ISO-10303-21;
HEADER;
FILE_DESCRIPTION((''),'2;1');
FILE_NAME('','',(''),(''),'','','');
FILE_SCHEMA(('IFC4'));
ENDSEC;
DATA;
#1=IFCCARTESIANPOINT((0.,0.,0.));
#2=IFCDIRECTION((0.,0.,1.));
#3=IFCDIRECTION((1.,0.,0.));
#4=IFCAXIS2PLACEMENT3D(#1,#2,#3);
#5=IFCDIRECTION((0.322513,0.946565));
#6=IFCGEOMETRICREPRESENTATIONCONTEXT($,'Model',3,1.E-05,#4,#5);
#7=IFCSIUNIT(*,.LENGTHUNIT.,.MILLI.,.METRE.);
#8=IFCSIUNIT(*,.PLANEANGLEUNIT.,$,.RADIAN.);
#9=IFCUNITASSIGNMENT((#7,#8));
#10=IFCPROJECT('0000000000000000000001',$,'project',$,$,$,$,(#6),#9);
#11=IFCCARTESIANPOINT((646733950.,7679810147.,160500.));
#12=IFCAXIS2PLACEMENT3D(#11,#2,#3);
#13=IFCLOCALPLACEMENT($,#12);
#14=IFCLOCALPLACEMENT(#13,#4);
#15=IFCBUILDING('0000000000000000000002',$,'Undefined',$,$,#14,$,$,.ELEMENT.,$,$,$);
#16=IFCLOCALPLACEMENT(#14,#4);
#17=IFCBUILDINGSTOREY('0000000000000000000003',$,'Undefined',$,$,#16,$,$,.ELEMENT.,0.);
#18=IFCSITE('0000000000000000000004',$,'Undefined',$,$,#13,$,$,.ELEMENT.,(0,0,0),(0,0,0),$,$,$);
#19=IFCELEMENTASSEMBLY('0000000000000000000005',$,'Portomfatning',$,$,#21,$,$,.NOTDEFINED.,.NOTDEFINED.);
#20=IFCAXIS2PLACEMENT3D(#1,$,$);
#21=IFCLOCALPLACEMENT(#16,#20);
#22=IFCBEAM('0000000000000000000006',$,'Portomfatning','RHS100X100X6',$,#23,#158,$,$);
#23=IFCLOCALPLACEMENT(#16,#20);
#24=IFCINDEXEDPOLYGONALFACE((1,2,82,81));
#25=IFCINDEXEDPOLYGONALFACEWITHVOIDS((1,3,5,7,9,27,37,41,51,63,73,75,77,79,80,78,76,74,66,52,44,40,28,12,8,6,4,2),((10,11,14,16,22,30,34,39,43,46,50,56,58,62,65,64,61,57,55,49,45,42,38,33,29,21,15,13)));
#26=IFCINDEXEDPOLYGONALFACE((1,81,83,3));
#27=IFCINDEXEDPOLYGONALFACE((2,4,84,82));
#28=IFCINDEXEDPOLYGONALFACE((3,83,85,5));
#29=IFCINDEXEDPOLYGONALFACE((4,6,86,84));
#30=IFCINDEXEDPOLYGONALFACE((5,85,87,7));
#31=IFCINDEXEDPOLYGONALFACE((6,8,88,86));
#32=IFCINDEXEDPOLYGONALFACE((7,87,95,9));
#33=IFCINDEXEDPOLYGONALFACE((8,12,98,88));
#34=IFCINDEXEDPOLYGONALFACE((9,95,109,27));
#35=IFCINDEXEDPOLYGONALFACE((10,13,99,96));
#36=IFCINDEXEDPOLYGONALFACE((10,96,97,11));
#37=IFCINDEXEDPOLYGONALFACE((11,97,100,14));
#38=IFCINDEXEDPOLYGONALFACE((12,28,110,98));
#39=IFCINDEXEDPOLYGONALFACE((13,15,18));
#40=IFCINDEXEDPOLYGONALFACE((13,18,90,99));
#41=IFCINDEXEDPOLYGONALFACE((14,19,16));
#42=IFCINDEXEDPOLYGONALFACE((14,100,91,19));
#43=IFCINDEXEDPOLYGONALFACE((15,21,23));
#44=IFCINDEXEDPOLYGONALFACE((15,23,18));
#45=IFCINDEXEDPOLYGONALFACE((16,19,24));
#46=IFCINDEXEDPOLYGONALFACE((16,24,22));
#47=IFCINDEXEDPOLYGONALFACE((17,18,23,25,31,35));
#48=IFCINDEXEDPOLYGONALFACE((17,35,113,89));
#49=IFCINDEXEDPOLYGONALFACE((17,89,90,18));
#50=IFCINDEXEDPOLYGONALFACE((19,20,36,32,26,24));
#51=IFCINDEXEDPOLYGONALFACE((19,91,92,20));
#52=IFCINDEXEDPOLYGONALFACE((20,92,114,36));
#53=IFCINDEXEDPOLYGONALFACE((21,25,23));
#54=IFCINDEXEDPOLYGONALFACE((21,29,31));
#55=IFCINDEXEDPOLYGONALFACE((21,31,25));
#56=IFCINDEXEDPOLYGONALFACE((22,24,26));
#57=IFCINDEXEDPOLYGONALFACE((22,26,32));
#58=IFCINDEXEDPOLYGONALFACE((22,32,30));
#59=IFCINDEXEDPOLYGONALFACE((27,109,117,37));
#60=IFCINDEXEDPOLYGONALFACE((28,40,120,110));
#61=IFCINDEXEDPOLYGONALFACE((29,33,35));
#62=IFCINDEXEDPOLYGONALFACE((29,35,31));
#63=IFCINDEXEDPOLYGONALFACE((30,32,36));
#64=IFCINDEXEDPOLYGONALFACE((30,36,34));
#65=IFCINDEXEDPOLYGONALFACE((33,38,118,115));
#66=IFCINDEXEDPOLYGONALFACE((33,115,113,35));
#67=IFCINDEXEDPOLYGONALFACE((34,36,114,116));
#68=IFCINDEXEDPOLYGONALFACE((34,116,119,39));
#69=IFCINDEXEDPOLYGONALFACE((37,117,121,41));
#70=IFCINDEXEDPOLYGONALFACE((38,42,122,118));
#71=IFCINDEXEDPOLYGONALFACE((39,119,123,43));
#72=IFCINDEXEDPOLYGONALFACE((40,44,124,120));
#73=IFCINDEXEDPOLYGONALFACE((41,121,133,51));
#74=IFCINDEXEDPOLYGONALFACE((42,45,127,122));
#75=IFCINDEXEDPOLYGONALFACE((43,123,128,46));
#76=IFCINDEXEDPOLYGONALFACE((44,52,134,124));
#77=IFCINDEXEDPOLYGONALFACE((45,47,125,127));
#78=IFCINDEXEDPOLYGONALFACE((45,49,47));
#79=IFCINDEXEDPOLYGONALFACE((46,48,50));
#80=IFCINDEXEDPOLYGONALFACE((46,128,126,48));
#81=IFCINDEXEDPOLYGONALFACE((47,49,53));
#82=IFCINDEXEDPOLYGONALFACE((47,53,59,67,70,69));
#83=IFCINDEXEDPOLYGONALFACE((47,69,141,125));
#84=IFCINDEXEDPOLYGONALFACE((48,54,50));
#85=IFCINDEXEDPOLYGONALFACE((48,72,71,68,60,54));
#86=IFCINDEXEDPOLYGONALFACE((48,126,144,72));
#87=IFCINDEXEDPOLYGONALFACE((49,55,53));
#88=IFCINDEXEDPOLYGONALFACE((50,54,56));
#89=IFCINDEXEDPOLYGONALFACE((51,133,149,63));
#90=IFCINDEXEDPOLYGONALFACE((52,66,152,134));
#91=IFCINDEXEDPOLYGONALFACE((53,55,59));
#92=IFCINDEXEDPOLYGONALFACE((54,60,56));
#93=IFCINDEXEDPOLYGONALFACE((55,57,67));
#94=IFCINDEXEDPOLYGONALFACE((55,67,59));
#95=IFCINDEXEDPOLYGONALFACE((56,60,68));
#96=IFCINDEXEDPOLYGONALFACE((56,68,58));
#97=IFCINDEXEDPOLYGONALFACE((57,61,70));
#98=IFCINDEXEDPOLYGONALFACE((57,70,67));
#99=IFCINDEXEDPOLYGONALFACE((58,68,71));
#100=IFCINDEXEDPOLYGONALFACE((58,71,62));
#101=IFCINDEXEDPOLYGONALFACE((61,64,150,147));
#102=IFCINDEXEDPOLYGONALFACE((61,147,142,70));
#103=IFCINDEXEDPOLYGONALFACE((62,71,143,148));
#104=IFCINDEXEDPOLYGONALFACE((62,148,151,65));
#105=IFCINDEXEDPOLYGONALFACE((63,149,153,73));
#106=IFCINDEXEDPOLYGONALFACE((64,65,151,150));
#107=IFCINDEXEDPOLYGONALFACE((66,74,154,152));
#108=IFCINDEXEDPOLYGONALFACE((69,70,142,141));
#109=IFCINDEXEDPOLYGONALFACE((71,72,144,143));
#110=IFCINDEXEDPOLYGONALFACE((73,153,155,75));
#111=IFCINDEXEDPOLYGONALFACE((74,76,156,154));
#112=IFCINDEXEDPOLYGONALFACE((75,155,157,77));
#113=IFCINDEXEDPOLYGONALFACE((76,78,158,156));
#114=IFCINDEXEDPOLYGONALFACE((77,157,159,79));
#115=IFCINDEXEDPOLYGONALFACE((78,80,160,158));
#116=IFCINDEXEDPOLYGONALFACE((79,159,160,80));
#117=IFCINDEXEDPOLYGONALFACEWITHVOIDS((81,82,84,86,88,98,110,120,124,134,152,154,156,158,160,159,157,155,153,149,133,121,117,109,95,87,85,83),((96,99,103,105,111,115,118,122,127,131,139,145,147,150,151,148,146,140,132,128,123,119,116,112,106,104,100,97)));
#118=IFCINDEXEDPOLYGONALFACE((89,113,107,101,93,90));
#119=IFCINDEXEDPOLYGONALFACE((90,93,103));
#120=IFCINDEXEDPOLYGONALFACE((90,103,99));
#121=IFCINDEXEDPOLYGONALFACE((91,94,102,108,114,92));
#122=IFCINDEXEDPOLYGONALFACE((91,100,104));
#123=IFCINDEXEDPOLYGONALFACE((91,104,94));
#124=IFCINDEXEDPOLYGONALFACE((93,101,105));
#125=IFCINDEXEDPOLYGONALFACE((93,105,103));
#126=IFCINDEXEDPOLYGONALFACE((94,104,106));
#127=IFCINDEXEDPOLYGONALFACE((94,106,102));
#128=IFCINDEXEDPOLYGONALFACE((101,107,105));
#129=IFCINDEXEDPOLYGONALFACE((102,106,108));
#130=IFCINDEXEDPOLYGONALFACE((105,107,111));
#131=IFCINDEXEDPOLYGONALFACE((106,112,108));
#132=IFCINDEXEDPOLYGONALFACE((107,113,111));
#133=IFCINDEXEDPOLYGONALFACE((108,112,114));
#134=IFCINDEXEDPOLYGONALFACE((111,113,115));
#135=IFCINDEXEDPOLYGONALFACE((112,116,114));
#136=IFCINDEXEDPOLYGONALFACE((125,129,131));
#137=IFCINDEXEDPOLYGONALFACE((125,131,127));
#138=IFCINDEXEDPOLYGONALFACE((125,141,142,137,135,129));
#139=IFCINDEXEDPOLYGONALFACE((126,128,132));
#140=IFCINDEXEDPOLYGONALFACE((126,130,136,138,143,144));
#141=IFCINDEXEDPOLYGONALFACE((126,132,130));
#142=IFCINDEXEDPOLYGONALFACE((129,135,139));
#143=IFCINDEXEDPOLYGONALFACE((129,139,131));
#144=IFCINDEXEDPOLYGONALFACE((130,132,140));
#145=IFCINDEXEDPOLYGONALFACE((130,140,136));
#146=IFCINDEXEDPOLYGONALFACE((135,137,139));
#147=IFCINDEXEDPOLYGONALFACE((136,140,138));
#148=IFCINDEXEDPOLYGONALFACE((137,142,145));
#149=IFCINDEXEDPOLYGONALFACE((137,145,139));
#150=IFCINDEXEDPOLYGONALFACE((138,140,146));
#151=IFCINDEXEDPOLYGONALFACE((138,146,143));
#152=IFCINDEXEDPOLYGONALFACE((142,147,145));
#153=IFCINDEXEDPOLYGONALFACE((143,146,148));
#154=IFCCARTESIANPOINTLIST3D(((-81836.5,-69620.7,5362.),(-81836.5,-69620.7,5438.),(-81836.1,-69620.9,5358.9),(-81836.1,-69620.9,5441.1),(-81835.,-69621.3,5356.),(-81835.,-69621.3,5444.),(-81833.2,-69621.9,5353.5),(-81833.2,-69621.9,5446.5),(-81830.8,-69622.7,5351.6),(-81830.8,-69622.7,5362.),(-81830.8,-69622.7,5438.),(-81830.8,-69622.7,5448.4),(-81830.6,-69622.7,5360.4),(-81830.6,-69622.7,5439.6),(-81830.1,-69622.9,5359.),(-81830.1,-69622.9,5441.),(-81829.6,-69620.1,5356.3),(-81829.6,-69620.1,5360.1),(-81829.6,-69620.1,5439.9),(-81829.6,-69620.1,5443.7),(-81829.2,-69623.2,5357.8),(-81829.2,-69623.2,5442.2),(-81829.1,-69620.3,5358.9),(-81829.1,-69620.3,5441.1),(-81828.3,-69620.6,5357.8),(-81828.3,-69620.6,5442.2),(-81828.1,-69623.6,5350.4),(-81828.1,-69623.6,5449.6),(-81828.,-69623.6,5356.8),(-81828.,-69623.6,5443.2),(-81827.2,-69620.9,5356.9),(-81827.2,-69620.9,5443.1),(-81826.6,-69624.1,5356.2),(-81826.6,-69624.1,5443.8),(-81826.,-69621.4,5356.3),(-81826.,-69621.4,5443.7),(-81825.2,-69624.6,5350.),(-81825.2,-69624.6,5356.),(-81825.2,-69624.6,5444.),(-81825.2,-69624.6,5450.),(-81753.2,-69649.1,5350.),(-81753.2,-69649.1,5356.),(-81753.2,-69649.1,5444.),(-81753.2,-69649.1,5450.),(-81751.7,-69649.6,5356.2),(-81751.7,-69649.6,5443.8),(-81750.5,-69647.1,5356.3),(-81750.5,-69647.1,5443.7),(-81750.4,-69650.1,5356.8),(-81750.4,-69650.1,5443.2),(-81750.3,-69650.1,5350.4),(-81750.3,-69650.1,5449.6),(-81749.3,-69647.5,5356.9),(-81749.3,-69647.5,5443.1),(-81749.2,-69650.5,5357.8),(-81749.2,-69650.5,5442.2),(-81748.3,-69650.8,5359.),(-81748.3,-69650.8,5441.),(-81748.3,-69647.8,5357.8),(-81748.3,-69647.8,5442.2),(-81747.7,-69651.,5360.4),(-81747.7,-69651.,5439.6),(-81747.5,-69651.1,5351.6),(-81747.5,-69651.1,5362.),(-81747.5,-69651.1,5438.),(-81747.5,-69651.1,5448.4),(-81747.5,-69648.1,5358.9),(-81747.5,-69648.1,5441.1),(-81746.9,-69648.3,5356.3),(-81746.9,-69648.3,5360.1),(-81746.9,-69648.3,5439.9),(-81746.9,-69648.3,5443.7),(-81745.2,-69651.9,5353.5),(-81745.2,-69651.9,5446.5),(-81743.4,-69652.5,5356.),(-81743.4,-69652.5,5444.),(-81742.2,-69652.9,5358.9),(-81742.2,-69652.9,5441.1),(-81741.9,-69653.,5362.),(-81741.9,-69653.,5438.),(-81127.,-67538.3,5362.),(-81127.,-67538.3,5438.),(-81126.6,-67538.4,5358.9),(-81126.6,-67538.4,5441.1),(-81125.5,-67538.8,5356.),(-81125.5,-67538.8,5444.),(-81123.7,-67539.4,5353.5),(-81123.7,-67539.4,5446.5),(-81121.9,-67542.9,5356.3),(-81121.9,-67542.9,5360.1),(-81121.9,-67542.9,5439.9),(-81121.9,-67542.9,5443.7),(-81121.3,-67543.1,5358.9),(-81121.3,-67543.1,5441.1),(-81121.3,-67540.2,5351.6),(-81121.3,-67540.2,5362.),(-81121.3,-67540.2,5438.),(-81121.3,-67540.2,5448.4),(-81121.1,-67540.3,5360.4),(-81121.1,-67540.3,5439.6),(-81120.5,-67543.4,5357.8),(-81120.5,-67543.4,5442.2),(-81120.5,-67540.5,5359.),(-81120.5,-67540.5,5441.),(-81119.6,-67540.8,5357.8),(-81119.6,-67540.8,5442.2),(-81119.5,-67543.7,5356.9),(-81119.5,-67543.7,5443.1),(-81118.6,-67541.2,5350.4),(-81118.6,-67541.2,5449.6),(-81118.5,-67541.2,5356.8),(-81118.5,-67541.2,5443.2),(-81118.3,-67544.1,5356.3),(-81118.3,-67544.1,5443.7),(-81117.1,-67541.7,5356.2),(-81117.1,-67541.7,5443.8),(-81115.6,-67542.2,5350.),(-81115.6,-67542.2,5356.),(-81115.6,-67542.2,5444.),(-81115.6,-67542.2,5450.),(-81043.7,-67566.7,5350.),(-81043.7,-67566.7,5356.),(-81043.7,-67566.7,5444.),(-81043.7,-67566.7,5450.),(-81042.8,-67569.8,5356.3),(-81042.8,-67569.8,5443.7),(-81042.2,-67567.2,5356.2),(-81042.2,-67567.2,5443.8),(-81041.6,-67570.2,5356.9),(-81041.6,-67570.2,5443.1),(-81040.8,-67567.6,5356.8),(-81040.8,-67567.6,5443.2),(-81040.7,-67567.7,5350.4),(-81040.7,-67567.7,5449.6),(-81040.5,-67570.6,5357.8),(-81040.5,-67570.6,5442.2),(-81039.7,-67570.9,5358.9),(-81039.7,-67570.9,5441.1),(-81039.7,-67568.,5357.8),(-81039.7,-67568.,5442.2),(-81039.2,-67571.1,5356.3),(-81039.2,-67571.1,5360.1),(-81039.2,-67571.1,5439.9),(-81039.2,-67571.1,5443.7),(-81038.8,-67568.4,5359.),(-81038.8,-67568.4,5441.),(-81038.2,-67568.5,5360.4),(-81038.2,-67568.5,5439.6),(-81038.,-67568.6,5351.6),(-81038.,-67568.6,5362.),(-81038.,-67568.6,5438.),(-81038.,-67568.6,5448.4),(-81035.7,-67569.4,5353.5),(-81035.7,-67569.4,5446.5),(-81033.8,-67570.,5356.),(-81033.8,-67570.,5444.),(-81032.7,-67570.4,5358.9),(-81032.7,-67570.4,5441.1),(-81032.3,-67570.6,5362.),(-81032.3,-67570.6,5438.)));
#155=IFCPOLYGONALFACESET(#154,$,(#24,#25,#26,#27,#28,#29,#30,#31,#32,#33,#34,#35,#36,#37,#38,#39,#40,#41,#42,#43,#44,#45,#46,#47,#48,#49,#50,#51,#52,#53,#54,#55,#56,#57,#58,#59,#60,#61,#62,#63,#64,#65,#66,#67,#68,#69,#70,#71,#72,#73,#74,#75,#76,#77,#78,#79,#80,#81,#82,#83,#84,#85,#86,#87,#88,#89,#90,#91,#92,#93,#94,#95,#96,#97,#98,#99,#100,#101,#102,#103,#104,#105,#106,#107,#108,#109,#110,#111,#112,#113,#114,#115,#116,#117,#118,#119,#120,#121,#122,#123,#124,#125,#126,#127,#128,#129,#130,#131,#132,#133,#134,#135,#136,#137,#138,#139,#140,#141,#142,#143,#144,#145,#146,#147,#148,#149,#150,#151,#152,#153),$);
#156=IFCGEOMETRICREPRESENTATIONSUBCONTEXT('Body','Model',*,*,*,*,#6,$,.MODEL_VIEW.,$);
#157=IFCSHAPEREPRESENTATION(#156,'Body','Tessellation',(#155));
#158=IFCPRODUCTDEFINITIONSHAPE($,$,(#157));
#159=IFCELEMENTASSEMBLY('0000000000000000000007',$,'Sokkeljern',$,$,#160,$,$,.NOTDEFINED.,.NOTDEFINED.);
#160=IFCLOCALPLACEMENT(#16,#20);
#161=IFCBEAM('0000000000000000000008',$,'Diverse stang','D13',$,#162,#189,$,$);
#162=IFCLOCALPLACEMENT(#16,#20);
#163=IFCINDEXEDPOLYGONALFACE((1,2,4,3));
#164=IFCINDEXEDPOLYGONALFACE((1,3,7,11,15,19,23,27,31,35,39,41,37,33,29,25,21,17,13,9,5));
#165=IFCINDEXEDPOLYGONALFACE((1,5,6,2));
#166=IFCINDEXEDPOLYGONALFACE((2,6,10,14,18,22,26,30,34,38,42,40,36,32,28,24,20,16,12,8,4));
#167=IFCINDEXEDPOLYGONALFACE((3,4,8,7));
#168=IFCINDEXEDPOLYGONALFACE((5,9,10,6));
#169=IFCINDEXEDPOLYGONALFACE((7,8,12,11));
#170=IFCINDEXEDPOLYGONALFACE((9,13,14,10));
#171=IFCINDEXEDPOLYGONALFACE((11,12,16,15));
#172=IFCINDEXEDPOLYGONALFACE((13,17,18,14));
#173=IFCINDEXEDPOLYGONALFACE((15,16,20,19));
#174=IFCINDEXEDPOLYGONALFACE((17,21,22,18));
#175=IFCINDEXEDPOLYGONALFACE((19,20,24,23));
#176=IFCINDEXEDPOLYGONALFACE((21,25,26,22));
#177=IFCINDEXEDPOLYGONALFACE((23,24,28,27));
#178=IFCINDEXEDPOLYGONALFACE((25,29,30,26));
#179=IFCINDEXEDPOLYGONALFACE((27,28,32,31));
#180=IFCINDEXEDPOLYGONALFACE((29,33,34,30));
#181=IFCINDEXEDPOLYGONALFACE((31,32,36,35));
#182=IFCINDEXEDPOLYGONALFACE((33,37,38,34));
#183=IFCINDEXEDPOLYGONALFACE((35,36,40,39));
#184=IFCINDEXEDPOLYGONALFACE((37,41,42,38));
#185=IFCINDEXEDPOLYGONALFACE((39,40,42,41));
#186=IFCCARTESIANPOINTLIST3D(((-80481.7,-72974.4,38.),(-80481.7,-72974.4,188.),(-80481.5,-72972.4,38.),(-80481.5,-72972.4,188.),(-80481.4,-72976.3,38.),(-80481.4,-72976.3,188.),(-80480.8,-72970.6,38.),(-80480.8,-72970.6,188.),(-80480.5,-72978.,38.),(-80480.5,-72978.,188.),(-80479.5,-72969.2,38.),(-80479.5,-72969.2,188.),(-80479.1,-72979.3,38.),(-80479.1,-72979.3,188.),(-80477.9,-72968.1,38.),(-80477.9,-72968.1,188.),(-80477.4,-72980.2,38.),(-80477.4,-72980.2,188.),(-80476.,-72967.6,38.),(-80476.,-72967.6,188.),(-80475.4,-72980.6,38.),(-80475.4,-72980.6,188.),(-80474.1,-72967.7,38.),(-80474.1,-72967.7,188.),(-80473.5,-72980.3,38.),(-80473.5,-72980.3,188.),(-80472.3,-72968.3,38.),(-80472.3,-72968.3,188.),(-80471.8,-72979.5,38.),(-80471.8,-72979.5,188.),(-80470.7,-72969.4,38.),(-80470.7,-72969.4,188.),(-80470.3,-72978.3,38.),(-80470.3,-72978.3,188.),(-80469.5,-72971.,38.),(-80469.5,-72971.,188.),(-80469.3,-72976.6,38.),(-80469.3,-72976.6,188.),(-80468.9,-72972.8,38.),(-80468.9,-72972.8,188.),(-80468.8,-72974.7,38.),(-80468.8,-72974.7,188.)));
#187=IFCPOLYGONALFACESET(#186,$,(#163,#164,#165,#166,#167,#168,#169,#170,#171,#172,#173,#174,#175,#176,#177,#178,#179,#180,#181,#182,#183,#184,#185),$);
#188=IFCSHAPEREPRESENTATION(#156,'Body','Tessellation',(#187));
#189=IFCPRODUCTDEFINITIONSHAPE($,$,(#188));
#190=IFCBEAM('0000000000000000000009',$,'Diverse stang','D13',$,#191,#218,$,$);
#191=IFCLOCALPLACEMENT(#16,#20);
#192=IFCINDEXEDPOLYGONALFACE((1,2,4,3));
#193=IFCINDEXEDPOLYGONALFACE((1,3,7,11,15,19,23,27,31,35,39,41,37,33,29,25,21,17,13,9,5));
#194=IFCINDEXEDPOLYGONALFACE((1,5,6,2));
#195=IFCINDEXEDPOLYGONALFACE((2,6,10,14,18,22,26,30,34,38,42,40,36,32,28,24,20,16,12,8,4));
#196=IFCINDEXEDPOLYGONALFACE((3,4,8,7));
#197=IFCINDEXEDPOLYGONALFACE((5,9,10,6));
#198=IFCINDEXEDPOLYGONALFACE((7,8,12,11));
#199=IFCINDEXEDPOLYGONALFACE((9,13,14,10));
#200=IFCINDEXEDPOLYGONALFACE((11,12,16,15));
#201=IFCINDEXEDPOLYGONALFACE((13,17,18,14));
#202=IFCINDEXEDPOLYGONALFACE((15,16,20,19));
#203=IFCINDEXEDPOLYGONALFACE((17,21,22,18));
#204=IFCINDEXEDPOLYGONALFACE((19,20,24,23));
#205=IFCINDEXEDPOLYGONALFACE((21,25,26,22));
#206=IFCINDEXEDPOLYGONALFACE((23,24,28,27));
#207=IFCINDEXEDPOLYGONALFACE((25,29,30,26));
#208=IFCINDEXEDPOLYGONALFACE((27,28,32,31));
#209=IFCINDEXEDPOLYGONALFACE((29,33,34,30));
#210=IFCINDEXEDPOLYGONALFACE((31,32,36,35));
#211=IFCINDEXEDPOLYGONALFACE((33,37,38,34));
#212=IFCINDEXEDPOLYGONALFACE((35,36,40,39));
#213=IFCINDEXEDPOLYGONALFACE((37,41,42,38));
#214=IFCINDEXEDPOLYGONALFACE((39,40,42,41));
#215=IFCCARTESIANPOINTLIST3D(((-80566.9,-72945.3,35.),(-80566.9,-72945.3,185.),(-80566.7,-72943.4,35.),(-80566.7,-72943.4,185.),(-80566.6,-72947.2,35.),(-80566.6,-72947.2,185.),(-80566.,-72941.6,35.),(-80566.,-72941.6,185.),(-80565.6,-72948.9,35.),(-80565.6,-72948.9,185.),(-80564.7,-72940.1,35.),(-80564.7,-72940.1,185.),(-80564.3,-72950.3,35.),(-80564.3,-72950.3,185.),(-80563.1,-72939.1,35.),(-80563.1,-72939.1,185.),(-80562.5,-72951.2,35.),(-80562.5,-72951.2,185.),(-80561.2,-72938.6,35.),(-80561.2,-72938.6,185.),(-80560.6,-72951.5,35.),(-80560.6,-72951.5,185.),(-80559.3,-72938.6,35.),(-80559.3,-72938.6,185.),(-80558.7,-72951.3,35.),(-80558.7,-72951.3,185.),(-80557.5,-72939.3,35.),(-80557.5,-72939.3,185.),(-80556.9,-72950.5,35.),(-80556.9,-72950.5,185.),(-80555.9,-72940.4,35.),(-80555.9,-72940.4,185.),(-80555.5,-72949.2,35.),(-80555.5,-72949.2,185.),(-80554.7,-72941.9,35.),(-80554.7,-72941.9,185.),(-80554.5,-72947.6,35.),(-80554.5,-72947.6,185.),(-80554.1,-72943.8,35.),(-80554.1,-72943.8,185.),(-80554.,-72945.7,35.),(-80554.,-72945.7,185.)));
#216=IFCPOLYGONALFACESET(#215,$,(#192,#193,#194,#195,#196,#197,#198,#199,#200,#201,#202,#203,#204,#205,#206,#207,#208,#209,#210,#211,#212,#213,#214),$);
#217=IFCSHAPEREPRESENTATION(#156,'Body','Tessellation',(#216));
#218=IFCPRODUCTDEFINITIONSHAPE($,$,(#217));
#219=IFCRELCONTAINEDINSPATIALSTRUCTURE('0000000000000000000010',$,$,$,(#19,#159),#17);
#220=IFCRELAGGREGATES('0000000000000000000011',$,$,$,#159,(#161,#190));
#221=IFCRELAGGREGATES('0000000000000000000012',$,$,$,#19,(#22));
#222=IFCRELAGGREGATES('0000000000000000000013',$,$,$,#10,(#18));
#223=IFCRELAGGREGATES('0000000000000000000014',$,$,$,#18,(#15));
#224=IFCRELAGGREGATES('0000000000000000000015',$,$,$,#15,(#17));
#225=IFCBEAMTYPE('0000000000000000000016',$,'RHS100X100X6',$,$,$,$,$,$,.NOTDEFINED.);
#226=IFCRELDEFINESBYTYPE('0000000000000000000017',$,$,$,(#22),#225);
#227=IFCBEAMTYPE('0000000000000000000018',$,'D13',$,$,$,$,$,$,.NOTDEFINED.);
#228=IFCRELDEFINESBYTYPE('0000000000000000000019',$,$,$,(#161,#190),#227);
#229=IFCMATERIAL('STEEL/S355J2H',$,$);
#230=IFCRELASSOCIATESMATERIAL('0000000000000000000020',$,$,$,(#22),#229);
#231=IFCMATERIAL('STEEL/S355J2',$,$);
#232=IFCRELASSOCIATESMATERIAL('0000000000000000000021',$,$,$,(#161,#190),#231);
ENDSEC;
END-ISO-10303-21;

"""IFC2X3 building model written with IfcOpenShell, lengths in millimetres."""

from ifc_helpers import new_model, si_unit, direction, frame, origin_with_axes, origin_2d_with_axis, place, context, subcontext, project, spatial, rectangle, hollow_rectangle, circle, extrude, boolean, halfspace, material, type_object, element, aggregate, save


model = new_model("IFC2X3")

# Units and contexts
model_context = context("Model", 3, precision=1e-05, world=origin_with_axes(), true_north=direction((0.322513, 0.946565)))
body_context = subcontext(model_context, "Body", "Model", "MODEL_VIEW")
ifc_project = project(units=[si_unit("LENGTHUNIT", "METRE", prefix="MILLI"), si_unit("PLANEANGLEUNIT", "RADIAN")], contexts=[model_context])

# Site, building, storey
site_placement = place(None, frame((646733950.0, 7679810147.0, 160500.0), z_axis=(0.0, 0.0, 1.0), x_axis=(1.0, 0.0, 0.0)))
site = spatial("IfcSite", under=ifc_project, at=site_placement, Name="Undefined", CompositionType="ELEMENT", RefLatitude=(0, 0, 0), RefLongitude=(0, 0, 0))
building_placement = place(site_placement, origin_with_axes())
building = spatial("IfcBuilding", under=site, at=building_placement, Name="Undefined", CompositionType="ELEMENT")
storey_placement = place(building_placement, origin_with_axes())
storey = spatial("IfcBuildingStorey", under=building, at=storey_placement, Name="Undefined", CompositionType="ELEMENT", Elevation=0.0)

# Shared definitions
ifc_material_1 = material(Name="STEEL/S355J2H")

# Shared definitions
ifc_material_2 = material(Name="STEEL/S355J2")

# Element assembly, beam
beam_type_1 = type_object("IfcBeamType", Name="RHS100X100X6", PredefinedType="NOTDEFINED")
assembly_1_placement = place(storey_placement, origin_with_axes())
assembly_1 = element("IfcElementAssembly", 1, at=assembly_1_placement, inside=storey, Name="Portomfatning", AssemblyPlace="NOTDEFINED", PredefinedType="NOTDEFINED")
beam_1_placement = place(assembly_1_placement, frame((-81076.4, -67545.0, 5400.0), z_axis=(0.946565, -0.322513, 0.0), x_axis=(-0.322513, -0.946565, 0.0)))
beam_1 = element("IfcBeam", 2, at=beam_1_placement, type_object=beam_type_1, material=ifc_material_1, Name="Portomfatning", Description="RHS100X100X6", context=body_context, shape_type="CSG", body=[
    boolean("DIFFERENCE", boolean("DIFFERENCE", boolean("DIFFERENCE", extrude(hollow_rectangle(XDim=100.0, YDim=100.0, WallThickness=6.0, InnerFilletRadius=6.0, OuterFilletRadius=12.0, at=origin_2d_with_axis()), frame((2271.7, 0.0, 0.0), z_axis=(-1.0, 0.0, 0.0), x_axis=(0.0, -1.0, 0.0)), (0.0, 0.0, 1.0), 2323.3), extrude(rectangle(XDim=87.4, YDim=87.4, at=origin_2d_with_axis()), frame((2207.2, 0.0, 0.0), z_axis=(-1.0, 0.0, 0.0), x_axis=(0.0, -1.0, 0.0)), (0.0, 0.0, 1.0), 2194.5)), halfspace(frame((2210.0, 50.0, 0.0), z_axis=(-1.0, 0.0, 0.0), x_axis=(0.0, 0.0, 1.0)), True)), halfspace(frame((10.0, 50.0, 0.0), z_axis=(1.0, 0.0, 0.0), x_axis=(0.0, 0.0, -1.0)), True)),
])

# Element assembly, beams
assembly_2_placement = place(storey_placement, origin_with_axes())
assembly_2 = element("IfcElementAssembly", 3, at=assembly_2_placement, inside=storey, Name="Sokkeljern", AssemblyPlace="NOTDEFINED", PredefinedType="NOTDEFINED")
beam_type_2 = type_object("IfcBeamType", Name="D13", PredefinedType="NOTDEFINED")
beam_2_placement = place(assembly_2_placement, frame((-80475.3, -72974.1, 188.0), z_axis=(0.946565, -0.322513, 0.0), x_axis=(0.0, 0.0, -1.0)))
beam_2 = element("IfcBeam", 4, at=beam_2_placement, type_object=beam_type_2, material=ifc_material_2, Name="Diverse stang", Description="D13", context=body_context, shape_type="SweptSolid", body=[
    extrude(circle(Radius=6.5, at=origin_2d_with_axis()), frame((150.0, 0.0, 0.0), z_axis=(-1.0, 0.0, 0.0), x_axis=(0.0, -1.0, 0.0)), (0.0, 0.0, 1.0), 150.0),
])
beam_3_placement = place(assembly_2_placement, frame((-80560.4, -72945.0, 185.0), z_axis=(0.946565, -0.322513, 0.0), x_axis=(0.0, 0.0, -1.0)))
beam_3 = element("IfcBeam", 5, at=beam_3_placement, type_object=beam_type_2, material=ifc_material_2, Name="Diverse stang", Description="D13", context=body_context, shape_type="SweptSolid", body=[
    extrude(circle(Radius=6.5, at=origin_2d_with_axis()), frame((150.0, 0.0, 0.0), z_axis=(-1.0, 0.0, 0.0), x_axis=(0.0, -1.0, 0.0)), (0.0, 0.0, 1.0), 150.0),
])

aggregate(assembly_2, [beam_2, beam_3])

aggregate(assembly_1, [beam_1])

save(model, "model.ifc")
